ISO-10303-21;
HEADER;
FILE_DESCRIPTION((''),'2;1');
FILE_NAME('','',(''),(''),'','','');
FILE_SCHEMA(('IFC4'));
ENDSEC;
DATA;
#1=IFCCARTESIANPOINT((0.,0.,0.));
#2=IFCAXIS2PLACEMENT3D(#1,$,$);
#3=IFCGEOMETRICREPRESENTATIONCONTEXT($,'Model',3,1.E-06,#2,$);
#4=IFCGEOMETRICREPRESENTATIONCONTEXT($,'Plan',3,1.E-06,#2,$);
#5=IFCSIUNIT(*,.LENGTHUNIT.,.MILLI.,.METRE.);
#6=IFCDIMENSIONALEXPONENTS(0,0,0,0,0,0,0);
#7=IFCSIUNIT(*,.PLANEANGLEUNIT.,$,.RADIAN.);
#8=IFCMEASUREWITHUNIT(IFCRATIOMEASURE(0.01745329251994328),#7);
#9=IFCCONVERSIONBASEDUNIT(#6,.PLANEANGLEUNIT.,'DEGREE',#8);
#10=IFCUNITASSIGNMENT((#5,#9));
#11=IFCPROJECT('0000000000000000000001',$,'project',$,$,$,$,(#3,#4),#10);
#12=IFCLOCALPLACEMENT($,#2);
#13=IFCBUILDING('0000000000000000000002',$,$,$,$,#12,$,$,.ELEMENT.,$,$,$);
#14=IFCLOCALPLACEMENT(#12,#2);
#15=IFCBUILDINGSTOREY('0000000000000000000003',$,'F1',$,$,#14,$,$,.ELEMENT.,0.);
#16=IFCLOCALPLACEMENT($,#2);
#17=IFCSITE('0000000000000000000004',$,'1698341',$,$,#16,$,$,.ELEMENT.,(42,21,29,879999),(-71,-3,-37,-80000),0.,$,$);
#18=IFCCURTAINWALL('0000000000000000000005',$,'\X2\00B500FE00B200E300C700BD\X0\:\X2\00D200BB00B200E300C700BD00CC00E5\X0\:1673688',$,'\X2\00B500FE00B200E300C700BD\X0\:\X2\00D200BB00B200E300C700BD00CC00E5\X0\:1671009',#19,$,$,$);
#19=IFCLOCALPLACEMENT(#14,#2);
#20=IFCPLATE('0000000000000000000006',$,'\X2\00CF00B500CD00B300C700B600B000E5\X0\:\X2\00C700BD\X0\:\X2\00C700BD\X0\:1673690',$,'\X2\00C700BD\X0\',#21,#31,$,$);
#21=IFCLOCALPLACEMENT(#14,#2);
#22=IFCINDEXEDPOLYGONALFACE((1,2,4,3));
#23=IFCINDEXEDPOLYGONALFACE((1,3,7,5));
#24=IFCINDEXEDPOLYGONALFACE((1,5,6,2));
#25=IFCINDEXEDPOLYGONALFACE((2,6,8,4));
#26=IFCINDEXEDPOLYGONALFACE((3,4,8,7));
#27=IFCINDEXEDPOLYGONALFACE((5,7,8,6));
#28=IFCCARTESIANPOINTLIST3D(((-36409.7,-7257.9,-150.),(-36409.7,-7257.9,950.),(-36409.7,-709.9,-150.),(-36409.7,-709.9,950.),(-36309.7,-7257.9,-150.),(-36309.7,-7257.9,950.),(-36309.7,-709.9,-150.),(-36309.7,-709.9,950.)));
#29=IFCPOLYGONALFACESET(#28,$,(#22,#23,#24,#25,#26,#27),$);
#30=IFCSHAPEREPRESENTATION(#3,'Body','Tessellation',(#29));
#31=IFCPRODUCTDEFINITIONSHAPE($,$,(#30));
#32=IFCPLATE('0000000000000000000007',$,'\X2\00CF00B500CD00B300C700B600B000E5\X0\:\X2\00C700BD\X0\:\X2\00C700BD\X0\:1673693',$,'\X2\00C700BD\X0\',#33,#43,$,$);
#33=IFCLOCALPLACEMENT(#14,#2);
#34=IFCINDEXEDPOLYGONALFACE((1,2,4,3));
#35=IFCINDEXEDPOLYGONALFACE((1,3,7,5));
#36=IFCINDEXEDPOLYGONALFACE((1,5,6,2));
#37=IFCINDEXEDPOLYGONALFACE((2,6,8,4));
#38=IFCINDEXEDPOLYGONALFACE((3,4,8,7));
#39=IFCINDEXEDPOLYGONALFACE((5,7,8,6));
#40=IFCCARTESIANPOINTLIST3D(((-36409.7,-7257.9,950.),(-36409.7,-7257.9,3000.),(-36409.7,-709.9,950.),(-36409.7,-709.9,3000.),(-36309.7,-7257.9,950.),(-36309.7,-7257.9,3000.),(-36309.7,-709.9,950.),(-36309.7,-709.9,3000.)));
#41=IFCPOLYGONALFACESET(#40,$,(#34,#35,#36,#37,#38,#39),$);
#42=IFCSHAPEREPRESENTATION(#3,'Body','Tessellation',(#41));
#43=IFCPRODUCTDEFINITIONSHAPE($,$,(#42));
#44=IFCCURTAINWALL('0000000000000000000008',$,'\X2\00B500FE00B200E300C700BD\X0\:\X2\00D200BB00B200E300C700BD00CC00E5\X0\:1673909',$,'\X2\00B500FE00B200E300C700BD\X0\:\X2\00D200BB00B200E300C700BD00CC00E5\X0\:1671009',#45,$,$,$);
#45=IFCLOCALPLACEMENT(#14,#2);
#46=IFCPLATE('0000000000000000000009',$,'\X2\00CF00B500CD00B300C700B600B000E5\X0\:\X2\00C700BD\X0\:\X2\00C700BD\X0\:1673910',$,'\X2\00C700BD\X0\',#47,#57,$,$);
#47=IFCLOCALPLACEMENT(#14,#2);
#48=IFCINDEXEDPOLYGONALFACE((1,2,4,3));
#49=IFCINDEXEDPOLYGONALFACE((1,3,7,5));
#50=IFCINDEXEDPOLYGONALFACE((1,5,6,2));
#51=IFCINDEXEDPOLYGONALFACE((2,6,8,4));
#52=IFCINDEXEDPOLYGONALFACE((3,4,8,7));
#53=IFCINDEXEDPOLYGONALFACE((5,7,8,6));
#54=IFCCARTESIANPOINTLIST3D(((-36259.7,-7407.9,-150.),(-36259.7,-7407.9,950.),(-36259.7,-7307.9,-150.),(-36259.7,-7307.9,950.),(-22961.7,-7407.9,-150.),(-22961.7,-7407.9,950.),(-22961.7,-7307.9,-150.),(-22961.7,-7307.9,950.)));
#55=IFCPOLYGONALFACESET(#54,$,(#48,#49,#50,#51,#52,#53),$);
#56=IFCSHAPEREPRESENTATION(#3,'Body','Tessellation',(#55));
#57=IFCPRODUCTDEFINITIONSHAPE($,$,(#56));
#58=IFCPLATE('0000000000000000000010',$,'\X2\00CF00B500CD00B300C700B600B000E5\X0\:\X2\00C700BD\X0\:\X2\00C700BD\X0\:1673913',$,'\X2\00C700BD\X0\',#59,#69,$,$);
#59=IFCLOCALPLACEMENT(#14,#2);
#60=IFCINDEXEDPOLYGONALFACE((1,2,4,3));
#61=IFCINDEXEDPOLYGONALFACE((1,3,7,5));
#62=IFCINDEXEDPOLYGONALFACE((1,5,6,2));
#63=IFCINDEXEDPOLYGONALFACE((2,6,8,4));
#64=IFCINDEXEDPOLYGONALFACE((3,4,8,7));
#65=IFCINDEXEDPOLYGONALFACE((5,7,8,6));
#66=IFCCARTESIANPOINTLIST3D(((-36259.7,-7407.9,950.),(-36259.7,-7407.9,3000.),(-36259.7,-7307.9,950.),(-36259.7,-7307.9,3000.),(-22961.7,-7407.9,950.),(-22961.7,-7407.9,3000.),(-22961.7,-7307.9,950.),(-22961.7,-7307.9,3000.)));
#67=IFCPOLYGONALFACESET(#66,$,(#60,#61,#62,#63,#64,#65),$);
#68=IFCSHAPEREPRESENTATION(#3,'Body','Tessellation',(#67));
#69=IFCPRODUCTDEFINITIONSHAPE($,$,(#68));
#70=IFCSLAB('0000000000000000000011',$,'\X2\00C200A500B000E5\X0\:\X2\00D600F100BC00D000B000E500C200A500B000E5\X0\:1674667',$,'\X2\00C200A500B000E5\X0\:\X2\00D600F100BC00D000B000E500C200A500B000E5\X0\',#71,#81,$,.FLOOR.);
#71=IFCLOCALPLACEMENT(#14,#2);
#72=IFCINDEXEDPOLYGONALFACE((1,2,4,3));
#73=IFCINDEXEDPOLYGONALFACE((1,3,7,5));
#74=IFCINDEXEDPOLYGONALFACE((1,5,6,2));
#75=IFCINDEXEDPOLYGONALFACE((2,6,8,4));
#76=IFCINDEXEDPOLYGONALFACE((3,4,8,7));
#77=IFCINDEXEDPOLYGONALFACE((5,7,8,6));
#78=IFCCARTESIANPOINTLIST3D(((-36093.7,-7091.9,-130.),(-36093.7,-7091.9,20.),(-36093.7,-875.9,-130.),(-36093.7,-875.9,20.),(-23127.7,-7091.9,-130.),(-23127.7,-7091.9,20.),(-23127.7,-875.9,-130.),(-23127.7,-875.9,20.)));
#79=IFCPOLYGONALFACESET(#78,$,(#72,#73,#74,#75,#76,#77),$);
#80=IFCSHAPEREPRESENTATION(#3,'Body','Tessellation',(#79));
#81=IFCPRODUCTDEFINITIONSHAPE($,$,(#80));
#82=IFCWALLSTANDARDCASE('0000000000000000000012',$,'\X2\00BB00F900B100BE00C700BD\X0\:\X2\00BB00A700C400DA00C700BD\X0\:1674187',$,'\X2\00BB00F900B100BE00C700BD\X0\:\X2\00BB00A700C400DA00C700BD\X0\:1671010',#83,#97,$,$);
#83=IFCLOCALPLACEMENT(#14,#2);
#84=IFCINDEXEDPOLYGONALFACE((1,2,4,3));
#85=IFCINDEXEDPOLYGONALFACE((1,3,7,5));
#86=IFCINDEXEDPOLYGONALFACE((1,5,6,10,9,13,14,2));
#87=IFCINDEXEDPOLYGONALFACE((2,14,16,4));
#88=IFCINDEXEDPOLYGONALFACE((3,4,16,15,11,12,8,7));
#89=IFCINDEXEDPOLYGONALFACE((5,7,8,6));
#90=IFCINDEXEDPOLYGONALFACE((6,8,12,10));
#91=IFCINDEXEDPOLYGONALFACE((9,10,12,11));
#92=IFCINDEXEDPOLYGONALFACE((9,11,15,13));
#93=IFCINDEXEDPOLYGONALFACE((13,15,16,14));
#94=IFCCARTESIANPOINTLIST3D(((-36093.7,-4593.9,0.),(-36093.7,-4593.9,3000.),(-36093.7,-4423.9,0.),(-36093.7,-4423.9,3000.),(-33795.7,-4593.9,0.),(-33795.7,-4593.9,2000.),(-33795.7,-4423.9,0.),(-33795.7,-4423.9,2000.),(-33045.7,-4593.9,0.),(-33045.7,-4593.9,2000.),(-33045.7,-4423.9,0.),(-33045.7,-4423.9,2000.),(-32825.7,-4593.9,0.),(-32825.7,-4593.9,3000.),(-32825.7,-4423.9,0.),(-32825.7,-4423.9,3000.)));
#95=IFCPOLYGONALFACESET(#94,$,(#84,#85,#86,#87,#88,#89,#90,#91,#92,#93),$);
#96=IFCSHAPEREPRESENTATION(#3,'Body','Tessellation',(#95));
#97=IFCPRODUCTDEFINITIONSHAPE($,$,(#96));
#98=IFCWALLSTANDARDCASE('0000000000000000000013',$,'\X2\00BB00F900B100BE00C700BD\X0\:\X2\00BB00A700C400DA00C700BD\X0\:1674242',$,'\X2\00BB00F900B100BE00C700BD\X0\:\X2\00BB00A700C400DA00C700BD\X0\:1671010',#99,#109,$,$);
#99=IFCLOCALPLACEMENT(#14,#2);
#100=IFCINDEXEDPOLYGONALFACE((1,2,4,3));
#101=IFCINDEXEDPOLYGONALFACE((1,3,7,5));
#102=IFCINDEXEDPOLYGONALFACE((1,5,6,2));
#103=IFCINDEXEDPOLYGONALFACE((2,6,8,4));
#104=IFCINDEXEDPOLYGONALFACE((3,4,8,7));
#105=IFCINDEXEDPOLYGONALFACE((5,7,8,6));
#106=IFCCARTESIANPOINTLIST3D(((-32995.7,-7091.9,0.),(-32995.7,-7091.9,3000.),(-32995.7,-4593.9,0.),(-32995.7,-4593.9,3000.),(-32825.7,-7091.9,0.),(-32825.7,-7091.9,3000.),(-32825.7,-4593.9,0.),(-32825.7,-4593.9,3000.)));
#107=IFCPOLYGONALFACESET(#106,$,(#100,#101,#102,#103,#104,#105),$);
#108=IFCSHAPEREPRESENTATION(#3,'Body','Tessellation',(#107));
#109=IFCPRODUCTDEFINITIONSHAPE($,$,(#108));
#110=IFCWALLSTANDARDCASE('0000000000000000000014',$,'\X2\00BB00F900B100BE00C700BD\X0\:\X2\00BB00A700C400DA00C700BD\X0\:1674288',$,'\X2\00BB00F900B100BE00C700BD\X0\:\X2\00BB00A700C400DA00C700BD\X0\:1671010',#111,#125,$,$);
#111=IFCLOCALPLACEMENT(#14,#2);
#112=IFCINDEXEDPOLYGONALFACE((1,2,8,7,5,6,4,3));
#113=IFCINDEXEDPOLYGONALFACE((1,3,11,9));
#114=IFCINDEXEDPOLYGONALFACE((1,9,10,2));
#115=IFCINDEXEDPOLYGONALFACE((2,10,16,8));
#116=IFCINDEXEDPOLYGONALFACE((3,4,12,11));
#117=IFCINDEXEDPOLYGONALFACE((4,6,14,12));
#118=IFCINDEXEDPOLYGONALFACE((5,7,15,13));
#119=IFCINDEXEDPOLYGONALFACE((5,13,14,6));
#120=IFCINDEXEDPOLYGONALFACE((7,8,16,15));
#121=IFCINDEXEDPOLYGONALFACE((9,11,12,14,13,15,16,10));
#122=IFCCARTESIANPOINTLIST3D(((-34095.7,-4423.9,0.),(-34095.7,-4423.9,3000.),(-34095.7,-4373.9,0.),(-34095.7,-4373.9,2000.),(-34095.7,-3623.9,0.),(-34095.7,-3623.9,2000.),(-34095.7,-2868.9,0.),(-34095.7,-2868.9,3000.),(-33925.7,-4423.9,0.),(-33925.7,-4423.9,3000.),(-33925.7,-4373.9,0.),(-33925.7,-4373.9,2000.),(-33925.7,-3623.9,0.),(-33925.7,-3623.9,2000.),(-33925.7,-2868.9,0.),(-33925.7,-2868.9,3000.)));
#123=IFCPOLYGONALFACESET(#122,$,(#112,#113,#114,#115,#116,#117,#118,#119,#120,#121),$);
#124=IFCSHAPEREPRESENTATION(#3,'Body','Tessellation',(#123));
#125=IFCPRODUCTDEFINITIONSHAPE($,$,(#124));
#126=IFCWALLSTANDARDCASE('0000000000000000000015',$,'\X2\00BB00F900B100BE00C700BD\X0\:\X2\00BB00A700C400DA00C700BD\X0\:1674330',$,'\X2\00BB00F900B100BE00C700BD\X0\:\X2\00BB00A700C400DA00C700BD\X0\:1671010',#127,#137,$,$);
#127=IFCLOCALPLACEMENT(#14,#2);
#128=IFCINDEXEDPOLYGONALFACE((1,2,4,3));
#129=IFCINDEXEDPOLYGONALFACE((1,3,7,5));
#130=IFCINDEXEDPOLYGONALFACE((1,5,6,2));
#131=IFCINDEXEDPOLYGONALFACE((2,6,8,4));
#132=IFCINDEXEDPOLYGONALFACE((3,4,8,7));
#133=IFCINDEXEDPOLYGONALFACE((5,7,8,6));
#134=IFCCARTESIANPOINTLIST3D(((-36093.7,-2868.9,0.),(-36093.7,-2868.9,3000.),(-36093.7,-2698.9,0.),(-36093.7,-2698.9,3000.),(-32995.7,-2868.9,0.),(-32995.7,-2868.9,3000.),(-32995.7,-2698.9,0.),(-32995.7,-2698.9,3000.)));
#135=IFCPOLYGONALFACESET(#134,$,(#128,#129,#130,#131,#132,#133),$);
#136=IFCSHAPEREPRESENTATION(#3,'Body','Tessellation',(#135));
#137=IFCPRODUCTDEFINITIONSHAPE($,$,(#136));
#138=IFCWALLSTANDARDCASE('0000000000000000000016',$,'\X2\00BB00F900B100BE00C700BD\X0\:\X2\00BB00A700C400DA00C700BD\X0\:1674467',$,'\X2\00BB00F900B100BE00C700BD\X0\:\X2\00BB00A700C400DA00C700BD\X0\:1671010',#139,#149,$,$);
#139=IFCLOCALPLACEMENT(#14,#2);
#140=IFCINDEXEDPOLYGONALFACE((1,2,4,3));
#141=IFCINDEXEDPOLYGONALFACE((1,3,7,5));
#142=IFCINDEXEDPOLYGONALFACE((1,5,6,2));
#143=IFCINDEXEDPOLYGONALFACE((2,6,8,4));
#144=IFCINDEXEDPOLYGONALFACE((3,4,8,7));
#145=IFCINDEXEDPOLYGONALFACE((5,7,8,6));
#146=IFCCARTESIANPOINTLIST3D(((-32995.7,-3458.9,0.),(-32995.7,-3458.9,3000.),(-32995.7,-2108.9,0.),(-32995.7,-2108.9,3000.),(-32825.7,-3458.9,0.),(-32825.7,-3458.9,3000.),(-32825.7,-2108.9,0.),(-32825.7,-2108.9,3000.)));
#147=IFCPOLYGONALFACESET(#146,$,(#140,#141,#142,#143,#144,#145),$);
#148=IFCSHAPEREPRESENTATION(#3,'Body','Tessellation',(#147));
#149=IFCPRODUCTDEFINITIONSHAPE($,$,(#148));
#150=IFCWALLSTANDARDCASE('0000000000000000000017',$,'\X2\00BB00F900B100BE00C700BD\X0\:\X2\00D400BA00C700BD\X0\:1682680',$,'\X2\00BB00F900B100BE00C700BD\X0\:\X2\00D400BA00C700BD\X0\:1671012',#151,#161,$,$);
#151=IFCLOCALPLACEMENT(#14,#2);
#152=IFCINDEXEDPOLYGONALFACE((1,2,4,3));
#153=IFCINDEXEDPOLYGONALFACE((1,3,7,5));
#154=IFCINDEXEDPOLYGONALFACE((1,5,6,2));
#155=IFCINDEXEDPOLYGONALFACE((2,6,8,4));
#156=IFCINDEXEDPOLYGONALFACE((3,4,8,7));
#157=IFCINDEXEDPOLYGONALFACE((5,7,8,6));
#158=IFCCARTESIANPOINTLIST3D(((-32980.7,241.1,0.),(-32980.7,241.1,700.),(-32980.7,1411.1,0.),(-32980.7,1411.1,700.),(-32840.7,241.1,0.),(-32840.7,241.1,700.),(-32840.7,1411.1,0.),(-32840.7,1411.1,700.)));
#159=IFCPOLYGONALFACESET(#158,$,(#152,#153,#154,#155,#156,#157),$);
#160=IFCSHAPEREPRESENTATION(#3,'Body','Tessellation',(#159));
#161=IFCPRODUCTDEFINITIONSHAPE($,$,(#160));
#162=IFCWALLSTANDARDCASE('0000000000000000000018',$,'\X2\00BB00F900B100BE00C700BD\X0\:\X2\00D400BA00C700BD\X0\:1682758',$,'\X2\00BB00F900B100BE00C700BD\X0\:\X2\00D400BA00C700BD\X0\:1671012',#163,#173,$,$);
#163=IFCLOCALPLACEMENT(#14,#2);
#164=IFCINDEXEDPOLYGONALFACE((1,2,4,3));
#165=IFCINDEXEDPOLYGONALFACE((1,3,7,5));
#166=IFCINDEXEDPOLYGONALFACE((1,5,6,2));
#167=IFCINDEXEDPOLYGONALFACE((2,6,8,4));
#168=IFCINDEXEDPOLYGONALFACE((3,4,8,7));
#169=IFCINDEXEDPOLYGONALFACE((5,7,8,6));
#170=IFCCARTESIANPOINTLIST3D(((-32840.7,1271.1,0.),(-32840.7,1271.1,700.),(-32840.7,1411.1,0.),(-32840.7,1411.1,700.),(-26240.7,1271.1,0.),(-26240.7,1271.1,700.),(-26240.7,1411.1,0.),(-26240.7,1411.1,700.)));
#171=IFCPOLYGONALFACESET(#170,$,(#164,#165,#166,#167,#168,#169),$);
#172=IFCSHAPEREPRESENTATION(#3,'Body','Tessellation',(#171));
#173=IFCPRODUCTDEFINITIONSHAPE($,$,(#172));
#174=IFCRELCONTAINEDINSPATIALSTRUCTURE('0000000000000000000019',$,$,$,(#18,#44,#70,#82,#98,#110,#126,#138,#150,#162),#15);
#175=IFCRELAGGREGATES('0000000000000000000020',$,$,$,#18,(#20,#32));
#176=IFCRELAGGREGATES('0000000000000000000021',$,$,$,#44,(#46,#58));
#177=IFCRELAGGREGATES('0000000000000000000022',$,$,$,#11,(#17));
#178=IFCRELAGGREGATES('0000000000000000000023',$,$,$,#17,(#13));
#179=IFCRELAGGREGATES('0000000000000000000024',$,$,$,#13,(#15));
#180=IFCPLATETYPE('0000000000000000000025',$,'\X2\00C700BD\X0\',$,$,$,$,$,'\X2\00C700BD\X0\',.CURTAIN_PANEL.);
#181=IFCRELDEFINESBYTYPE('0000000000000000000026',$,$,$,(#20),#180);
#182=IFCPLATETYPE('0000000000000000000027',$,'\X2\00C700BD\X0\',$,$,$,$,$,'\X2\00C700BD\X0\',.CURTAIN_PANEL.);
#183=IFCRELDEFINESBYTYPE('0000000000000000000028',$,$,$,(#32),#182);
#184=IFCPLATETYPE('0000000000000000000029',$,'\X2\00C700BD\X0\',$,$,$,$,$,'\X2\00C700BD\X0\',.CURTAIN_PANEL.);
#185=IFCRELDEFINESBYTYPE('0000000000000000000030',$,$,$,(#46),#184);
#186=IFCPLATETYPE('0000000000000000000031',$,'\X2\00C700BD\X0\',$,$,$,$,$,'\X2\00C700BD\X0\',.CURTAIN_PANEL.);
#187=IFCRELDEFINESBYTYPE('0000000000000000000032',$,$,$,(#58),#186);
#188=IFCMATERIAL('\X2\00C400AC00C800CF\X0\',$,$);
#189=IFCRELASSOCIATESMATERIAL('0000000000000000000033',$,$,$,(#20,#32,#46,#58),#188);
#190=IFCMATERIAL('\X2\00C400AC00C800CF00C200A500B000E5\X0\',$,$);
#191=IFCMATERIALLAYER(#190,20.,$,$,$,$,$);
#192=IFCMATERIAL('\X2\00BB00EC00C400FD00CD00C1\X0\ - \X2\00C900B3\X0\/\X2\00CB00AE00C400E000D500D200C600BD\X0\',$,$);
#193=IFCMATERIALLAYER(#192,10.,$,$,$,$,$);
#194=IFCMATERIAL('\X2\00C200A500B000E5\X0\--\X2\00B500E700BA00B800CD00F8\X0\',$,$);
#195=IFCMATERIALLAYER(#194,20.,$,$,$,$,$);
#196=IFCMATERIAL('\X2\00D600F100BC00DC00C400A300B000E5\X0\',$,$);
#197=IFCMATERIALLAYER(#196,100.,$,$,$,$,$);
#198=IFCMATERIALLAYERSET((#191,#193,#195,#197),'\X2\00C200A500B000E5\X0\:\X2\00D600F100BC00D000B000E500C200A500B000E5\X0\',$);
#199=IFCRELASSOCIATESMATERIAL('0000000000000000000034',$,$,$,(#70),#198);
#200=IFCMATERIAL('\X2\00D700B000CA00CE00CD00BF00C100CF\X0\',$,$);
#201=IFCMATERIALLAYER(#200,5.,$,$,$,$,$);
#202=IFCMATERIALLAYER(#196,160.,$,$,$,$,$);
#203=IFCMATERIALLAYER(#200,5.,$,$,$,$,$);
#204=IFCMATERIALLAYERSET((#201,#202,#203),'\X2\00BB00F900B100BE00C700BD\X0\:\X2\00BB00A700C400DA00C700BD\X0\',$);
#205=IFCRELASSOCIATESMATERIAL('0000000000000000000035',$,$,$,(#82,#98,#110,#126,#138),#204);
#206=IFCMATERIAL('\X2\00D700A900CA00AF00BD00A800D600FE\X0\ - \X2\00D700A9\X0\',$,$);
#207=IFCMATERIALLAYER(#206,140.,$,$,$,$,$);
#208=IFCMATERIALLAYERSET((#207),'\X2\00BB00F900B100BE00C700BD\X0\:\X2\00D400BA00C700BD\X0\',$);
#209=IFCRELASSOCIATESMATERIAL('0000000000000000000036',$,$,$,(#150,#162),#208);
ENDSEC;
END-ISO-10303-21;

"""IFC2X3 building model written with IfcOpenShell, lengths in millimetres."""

from ifc_helpers import new_model, entity, si_unit, converted_unit, frame, frame_2d, origin, origin_2d_with_axis, place, context, project, spatial, rectangle, extrude, source, transform, mapped, material, layer, layer_set, layer_usage, type_object, type_shapes, element, aggregate, save


model = new_model("IFC2X3")

# Units and contexts
model_context = context("Model", 3, precision=1e-06, world=origin())
plan_context = context("Plan", 3, precision=1e-06, world=origin())
ifc_project = project(units=[si_unit("LENGTHUNIT", "METRE", prefix="MILLI"), converted_unit("PLANEANGLEUNIT", "DEGREE", entity("IfcRatioMeasure", 0.01745329251994328), si_unit("PLANEANGLEUNIT", "RADIAN"), dimensions=[0, 0, 0, 0, 0, 0, 0])], contexts=[model_context, plan_context])

# Site, building, storey
site_placement = place(None, origin())
site = spatial("IfcSite", under=ifc_project, at=site_placement, Name="1698341", CompositionType="ELEMENT", RefLatitude=(42, 21, 29, 879999), RefLongitude=(-71, -3, -37, -80000), RefElevation=0.0)
building_placement = place(None, origin())
building = spatial("IfcBuilding", under=site, at=building_placement, CompositionType="ELEMENT")
storey_placement = place(building_placement, origin())
storey = spatial("IfcBuildingStorey", under=building, at=storey_placement, Name="F1", CompositionType="ELEMENT", Elevation=0.0)

# Curtain walls, plates
curtain_wall_1_placement = place(storey_placement, origin())
curtain_wall_1 = element("IfcCurtainWall", 1, at=curtain_wall_1_placement, inside=storey, Name="µþ²ãÇ½:Ò»²ãÇ½Ìå:1673688", ObjectType="µþ²ãÇ½:Ò»²ãÇ½Ìå:1671009")
ifc_material_1 = material(Name="Ä¬ÈÏ")
plate_type_1 = type_object("IfcPlateType", Name="Ç½", ElementType="Ç½", PredefinedType="CURTAIN_PANEL")
shared_shape_1 = source(origin(), model_context, "Body", "SweptSolid", [
    extrude(rectangle(XDim=100.0, YDim=6548.0, at=origin_2d_with_axis()), frame((0.0, 100.0, 0.0), z_axis=(0.0, 0.0, 1.0), x_axis=(0.0, 1.0, 0.0)), (0.0, 0.0, 1.0), 1100.0),
])
type_shapes(plate_type_1, [shared_shape_1])
plate_1_placement = place(None, frame((-36259.7, -3983.9, -150.0), z_axis=(0.0, 0.0, 1.0), x_axis=(0.0, 1.0, 0.0)))
plate_1 = element("IfcPlate", 2, at=plate_1_placement, type_object=plate_type_1, material=ifc_material_1, Name="ÏµÍ³Ç¶°å:Ç½:Ç½:1673690", ObjectType="Ç½", context=model_context, shape_type="MappedRepresentation", body=[
    mapped(shared_shape_1, transform((0.0, 0.0, 0.0), scale=1.0)),
])
plate_type_2 = type_object("IfcPlateType", Name="Ç½", ElementType="Ç½", PredefinedType="CURTAIN_PANEL")
shared_shape_2 = source(origin(), model_context, "Body", "SweptSolid", [
    extrude(rectangle(XDim=100.0, YDim=6548.0, at=origin_2d_with_axis()), frame((0.0, 100.0, 0.0), z_axis=(0.0, 0.0, 1.0), x_axis=(0.0, 1.0, 0.0)), (0.0, 0.0, 1.0), 2050.0),
])
type_shapes(plate_type_2, [shared_shape_2])
plate_2_placement = place(None, frame((-36259.7, -3983.9, 950.0), z_axis=(0.0, 0.0, 1.0), x_axis=(0.0, 1.0, 0.0)))
plate_2 = element("IfcPlate", 3, at=plate_2_placement, type_object=plate_type_2, material=ifc_material_1, Name="ÏµÍ³Ç¶°å:Ç½:Ç½:1673693", ObjectType="Ç½", context=model_context, shape_type="MappedRepresentation", body=[
    mapped(shared_shape_2, transform((0.0, 0.0, 0.0), scale=1.0)),
])
aggregate(curtain_wall_1, [plate_1, plate_2])
curtain_wall_2_placement = place(storey_placement, origin())
curtain_wall_2 = element("IfcCurtainWall", 4, at=curtain_wall_2_placement, inside=storey, Name="µþ²ãÇ½:Ò»²ãÇ½Ìå:1673909", ObjectType="µþ²ãÇ½:Ò»²ãÇ½Ìå:1671009")
plate_type_3 = type_object("IfcPlateType", Name="Ç½", ElementType="Ç½", PredefinedType="CURTAIN_PANEL")
shared_shape_3 = source(origin(), model_context, "Body", "SweptSolid", [
    extrude(rectangle(XDim=100.0, YDim=13298.0, at=origin_2d_with_axis()), frame((0.0, 100.0, 0.0), z_axis=(0.0, 0.0, 1.0), x_axis=(0.0, 1.0, 0.0)), (0.0, 0.0, 1.0), 1100.0),
])
type_shapes(plate_type_3, [shared_shape_3])
plate_3_placement = place(None, frame((-29610.7, -7257.9, -150.0), z_axis=(0.0, 0.0, 1.0), x_axis=(-1.0, 0.0, 0.0)))
plate_3 = element("IfcPlate", 5, at=plate_3_placement, type_object=plate_type_3, material=ifc_material_1, Name="ÏµÍ³Ç¶°å:Ç½:Ç½:1673910", ObjectType="Ç½", context=model_context, shape_type="MappedRepresentation", body=[
    mapped(shared_shape_3, transform((0.0, 0.0, 0.0), scale=1.0)),
])
plate_type_4 = type_object("IfcPlateType", Name="Ç½", ElementType="Ç½", PredefinedType="CURTAIN_PANEL")
shared_shape_4 = source(origin(), model_context, "Body", "SweptSolid", [
    extrude(rectangle(XDim=100.0, YDim=13298.0, at=origin_2d_with_axis()), frame((0.0, 100.0, 0.0), z_axis=(0.0, 0.0, 1.0), x_axis=(0.0, 1.0, 0.0)), (0.0, 0.0, 1.0), 2050.0),
])
type_shapes(plate_type_4, [shared_shape_4])
plate_4_placement = place(None, frame((-29610.7, -7257.9, 950.0), z_axis=(0.0, 0.0, 1.0), x_axis=(-1.0, 0.0, 0.0)))
plate_4 = element("IfcPlate", 6, at=plate_4_placement, type_object=plate_type_4, material=ifc_material_1, Name="ÏµÍ³Ç¶°å:Ç½:Ç½:1673913", ObjectType="Ç½", context=model_context, shape_type="MappedRepresentation", body=[
    mapped(shared_shape_4, transform((0.0, 0.0, 0.0), scale=1.0)),
])
aggregate(curtain_wall_2, [plate_3, plate_4])

# Slab
ifc_material_2 = material(Name="Ä¬ÈÏÂ¥°å")
ifc_layer_1 = layer(ifc_material_2, 20.0)
ifc_material_3 = material(Name="»ìÄýÍÁ - É³/Ë®ÄàÕÒÆ½")
ifc_layer_2 = layer(ifc_material_3, 10.0)
ifc_material_4 = material(Name="Â¥°å--µçº¸Íø")
ifc_layer_3 = layer(ifc_material_4, 20.0)
ifc_material_5 = material(Name="Öñ¼ÜÄ£°å")
ifc_layer_4 = layer(ifc_material_5, 100.0)
ifc_layer_set_1 = layer_set([ifc_layer_1, ifc_layer_2, ifc_layer_3, ifc_layer_4], Name="Â¥°å:Öñ¼Ð°åÂ¥°å")
ifc_layer_usage_1 = layer_usage(ifc_layer_set_1, "AXIS3", "POSITIVE", 0.0)
slab_placement = place(storey_placement, frame((-36093.7, -7091.9, -130.0)))
element("IfcSlab", 7, at=slab_placement, inside=storey, material=ifc_layer_usage_1, Name="Â¥°å:Öñ¼Ð°åÂ¥°å:1674667", ObjectType="Â¥°å:Öñ¼Ð°åÂ¥°å", PredefinedType="FLOOR", context=model_context, shape_type="SweptSolid", body=[
    extrude(rectangle(XDim=6216.0, YDim=12966.0, at=frame_2d((0.0, 0.0), x_axis=(0.0, -1.0))), frame((6483.0, 3108.0, 150.0), z_axis=(0.0, 0.0, -1.0), x_axis=(-1.0, 0.0, 0.0)), (0.0, 0.0, 1.0), 150.0),
])

# Shared definitions
ifc_material_6 = material(Name="×°ÊÎÍ¿ÁÏ")

# Wall, opening
ifc_layer_5 = layer(ifc_material_6, 5.0)
ifc_layer_6 = layer(ifc_material_5, 160.0)
ifc_layer_7 = layer(ifc_material_6, 5.0)
ifc_layer_set_2 = layer_set([ifc_layer_5, ifc_layer_6, ifc_layer_7], Name="»ù±¾Ç½:»§ÄÚÇ½")
ifc_layer_usage_2 = layer_usage(ifc_layer_set_2, "AXIS2", "NEGATIVE", 85.0)
wall_1_placement = place(storey_placement, frame((-36093.7, -4508.9, 0.0)))
wall_1 = element("IfcWallStandardCase", 8, at=wall_1_placement, inside=storey, material=ifc_layer_usage_2, Name="»ù±¾Ç½:»§ÄÚÇ½:1674187", ObjectType="»ù±¾Ç½:»§ÄÚÇ½:1671010", context=model_context, shape_type="SweptSolid", body=[
    extrude(rectangle(XDim=3268.0, YDim=170.0, at=frame_2d((1634.0, 0.0), x_axis=(-1.0, 0.0))), origin(), (0.0, 0.0, 1.0), 3000.0),
])
opening_1_placement = place(wall_1_placement, frame((3048.0, 85.0, 0.0)))
element("IfcOpeningElement", 9, at=opening_1_placement, cuts=wall_1, ObjectType="Opening", context=model_context, shape_type="SweptSolid", body=[
    extrude(rectangle(XDim=750.0, YDim=2000.0, at=frame_2d((1000.0, 375.0), x_axis=(0.0, -1.0))), frame((0.0, 0.0, 0.0), z_axis=(0.0, -1.0, 0.0), x_axis=(0.0, 0.0, 1.0)), (0.0, 0.0, 1.0), 170.0),
])

# Wall
ifc_layer_usage_3 = layer_usage(ifc_layer_set_2, "AXIS2", "NEGATIVE", 85.0)
wall_2_placement = place(storey_placement, frame((-32910.7, -4593.9, 0.0), z_axis=(0.0, 0.0, 1.0), x_axis=(0.0, -1.0, 0.0)))
element("IfcWallStandardCase", 10, at=wall_2_placement, inside=storey, material=ifc_layer_usage_3, Name="»ù±¾Ç½:»§ÄÚÇ½:1674242", ObjectType="»ù±¾Ç½:»§ÄÚÇ½:1671010", context=model_context, shape_type="SweptSolid", body=[
    extrude(rectangle(XDim=2498.0, YDim=170.0, at=frame_2d((1249.0, 0.0), x_axis=(-1.0, 0.0))), origin(), (0.0, 0.0, 1.0), 3000.0),
])

# Wall, opening
ifc_layer_usage_4 = layer_usage(ifc_layer_set_2, "AXIS2", "NEGATIVE", 85.0)
wall_3_placement = place(storey_placement, frame((-34010.7, -4423.9, 0.0), z_axis=(0.0, 0.0, 1.0), x_axis=(0.0, 1.0, 0.0)))
wall_3 = element("IfcWallStandardCase", 11, at=wall_3_placement, inside=storey, material=ifc_layer_usage_4, Name="»ù±¾Ç½:»§ÄÚÇ½:1674288", ObjectType="»ù±¾Ç½:»§ÄÚÇ½:1671010", context=model_context, shape_type="SweptSolid", body=[
    extrude(rectangle(XDim=1555.0, YDim=170.0, at=frame_2d((777.5, 0.0), x_axis=(-1.0, 0.0))), origin(), (0.0, 0.0, 1.0), 3000.0),
])
opening_2_placement = place(wall_3_placement, frame((50.0, -85.0, 0.0)))
element("IfcOpeningElement", 12, at=opening_2_placement, cuts=wall_3, ObjectType="Opening", context=model_context, shape_type="SweptSolid", body=[
    extrude(rectangle(XDim=750.0, YDim=2000.0, at=frame_2d((1000.0, 375.0), x_axis=(0.0, -1.0))), frame((0.0, 0.0, 0.0), z_axis=(0.0, 1.0, 0.0), x_axis=(0.0, 0.0, 1.0)), (0.0, 0.0, 1.0), 170.0),
])

# Walls
ifc_layer_usage_5 = layer_usage(ifc_layer_set_2, "AXIS2", "NEGATIVE", 85.0)
wall_4_placement = place(storey_placement, frame((-32995.7, -2783.9, 0.0), z_axis=(0.0, 0.0, 1.0), x_axis=(-1.0, 0.0, 0.0)))
element("IfcWallStandardCase", 13, at=wall_4_placement, inside=storey, material=ifc_layer_usage_5, Name="»ù±¾Ç½:»§ÄÚÇ½:1674330", ObjectType="»ù±¾Ç½:»§ÄÚÇ½:1671010", context=model_context, shape_type="SweptSolid", body=[
    extrude(rectangle(XDim=3098.0, YDim=170.0, at=frame_2d((1549.0, 0.0), x_axis=(-1.0, 0.0))), origin(), (0.0, 0.0, 1.0), 3000.0),
])
ifc_layer_usage_6 = layer_usage(ifc_layer_set_2, "AXIS2", "NEGATIVE", 85.0)
wall_5_placement = place(storey_placement, frame((-32910.7, -3458.9, 0.0), z_axis=(0.0, 0.0, 1.0), x_axis=(0.0, 1.0, 0.0)))
element("IfcWallStandardCase", 14, at=wall_5_placement, inside=storey, material=ifc_layer_usage_6, Name="»ù±¾Ç½:»§ÄÚÇ½:1674467", ObjectType="»ù±¾Ç½:»§ÄÚÇ½:1671010", context=model_context, shape_type="SweptSolid", body=[
    extrude(rectangle(XDim=1350.0, YDim=170.0, at=frame_2d((675.0, 0.0), x_axis=(-1.0, 0.0))), origin(), (0.0, 0.0, 1.0), 3000.0),
])
ifc_material_7 = material(Name="×©Ê¯½¨Öþ - ×©")
ifc_layer_8 = layer(ifc_material_7, 140.0)
ifc_layer_set_3 = layer_set([ifc_layer_8], Name="»ù±¾Ç½:ÔºÇ½")
ifc_layer_usage_7 = layer_usage(ifc_layer_set_3, "AXIS2", "NEGATIVE", 70.0)
wall_6_placement = place(storey_placement, frame((-32910.7, 241.1, 0.0), z_axis=(0.0, 0.0, 1.0), x_axis=(0.0, 1.0, 0.0)))
element("IfcWallStandardCase", 15, at=wall_6_placement, inside=storey, material=ifc_layer_usage_7, Name="»ù±¾Ç½:ÔºÇ½:1682680", ObjectType="»ù±¾Ç½:ÔºÇ½:1671012", context=model_context, shape_type="SweptSolid", body=[
    extrude(rectangle(XDim=1170.0, YDim=140.0, at=frame_2d((585.0, 0.0), x_axis=(-1.0, 0.0))), origin(), (0.0, 0.0, 1.0), 700.0),
])
ifc_layer_usage_8 = layer_usage(ifc_layer_set_3, "AXIS2", "NEGATIVE", 70.0)
wall_7_placement = place(storey_placement, frame((-32840.7, 1341.1, 0.0)))
element("IfcWallStandardCase", 16, at=wall_7_placement, inside=storey, material=ifc_layer_usage_8, Name="»ù±¾Ç½:ÔºÇ½:1682758", ObjectType="»ù±¾Ç½:ÔºÇ½:1671012", context=model_context, shape_type="SweptSolid", body=[
    extrude(rectangle(XDim=6600.0, YDim=140.0, at=frame_2d((3300.0, 0.0), x_axis=(-1.0, 0.0))), origin(), (0.0, 0.0, 1.0), 700.0),
])

save(model, "model.ifc")
